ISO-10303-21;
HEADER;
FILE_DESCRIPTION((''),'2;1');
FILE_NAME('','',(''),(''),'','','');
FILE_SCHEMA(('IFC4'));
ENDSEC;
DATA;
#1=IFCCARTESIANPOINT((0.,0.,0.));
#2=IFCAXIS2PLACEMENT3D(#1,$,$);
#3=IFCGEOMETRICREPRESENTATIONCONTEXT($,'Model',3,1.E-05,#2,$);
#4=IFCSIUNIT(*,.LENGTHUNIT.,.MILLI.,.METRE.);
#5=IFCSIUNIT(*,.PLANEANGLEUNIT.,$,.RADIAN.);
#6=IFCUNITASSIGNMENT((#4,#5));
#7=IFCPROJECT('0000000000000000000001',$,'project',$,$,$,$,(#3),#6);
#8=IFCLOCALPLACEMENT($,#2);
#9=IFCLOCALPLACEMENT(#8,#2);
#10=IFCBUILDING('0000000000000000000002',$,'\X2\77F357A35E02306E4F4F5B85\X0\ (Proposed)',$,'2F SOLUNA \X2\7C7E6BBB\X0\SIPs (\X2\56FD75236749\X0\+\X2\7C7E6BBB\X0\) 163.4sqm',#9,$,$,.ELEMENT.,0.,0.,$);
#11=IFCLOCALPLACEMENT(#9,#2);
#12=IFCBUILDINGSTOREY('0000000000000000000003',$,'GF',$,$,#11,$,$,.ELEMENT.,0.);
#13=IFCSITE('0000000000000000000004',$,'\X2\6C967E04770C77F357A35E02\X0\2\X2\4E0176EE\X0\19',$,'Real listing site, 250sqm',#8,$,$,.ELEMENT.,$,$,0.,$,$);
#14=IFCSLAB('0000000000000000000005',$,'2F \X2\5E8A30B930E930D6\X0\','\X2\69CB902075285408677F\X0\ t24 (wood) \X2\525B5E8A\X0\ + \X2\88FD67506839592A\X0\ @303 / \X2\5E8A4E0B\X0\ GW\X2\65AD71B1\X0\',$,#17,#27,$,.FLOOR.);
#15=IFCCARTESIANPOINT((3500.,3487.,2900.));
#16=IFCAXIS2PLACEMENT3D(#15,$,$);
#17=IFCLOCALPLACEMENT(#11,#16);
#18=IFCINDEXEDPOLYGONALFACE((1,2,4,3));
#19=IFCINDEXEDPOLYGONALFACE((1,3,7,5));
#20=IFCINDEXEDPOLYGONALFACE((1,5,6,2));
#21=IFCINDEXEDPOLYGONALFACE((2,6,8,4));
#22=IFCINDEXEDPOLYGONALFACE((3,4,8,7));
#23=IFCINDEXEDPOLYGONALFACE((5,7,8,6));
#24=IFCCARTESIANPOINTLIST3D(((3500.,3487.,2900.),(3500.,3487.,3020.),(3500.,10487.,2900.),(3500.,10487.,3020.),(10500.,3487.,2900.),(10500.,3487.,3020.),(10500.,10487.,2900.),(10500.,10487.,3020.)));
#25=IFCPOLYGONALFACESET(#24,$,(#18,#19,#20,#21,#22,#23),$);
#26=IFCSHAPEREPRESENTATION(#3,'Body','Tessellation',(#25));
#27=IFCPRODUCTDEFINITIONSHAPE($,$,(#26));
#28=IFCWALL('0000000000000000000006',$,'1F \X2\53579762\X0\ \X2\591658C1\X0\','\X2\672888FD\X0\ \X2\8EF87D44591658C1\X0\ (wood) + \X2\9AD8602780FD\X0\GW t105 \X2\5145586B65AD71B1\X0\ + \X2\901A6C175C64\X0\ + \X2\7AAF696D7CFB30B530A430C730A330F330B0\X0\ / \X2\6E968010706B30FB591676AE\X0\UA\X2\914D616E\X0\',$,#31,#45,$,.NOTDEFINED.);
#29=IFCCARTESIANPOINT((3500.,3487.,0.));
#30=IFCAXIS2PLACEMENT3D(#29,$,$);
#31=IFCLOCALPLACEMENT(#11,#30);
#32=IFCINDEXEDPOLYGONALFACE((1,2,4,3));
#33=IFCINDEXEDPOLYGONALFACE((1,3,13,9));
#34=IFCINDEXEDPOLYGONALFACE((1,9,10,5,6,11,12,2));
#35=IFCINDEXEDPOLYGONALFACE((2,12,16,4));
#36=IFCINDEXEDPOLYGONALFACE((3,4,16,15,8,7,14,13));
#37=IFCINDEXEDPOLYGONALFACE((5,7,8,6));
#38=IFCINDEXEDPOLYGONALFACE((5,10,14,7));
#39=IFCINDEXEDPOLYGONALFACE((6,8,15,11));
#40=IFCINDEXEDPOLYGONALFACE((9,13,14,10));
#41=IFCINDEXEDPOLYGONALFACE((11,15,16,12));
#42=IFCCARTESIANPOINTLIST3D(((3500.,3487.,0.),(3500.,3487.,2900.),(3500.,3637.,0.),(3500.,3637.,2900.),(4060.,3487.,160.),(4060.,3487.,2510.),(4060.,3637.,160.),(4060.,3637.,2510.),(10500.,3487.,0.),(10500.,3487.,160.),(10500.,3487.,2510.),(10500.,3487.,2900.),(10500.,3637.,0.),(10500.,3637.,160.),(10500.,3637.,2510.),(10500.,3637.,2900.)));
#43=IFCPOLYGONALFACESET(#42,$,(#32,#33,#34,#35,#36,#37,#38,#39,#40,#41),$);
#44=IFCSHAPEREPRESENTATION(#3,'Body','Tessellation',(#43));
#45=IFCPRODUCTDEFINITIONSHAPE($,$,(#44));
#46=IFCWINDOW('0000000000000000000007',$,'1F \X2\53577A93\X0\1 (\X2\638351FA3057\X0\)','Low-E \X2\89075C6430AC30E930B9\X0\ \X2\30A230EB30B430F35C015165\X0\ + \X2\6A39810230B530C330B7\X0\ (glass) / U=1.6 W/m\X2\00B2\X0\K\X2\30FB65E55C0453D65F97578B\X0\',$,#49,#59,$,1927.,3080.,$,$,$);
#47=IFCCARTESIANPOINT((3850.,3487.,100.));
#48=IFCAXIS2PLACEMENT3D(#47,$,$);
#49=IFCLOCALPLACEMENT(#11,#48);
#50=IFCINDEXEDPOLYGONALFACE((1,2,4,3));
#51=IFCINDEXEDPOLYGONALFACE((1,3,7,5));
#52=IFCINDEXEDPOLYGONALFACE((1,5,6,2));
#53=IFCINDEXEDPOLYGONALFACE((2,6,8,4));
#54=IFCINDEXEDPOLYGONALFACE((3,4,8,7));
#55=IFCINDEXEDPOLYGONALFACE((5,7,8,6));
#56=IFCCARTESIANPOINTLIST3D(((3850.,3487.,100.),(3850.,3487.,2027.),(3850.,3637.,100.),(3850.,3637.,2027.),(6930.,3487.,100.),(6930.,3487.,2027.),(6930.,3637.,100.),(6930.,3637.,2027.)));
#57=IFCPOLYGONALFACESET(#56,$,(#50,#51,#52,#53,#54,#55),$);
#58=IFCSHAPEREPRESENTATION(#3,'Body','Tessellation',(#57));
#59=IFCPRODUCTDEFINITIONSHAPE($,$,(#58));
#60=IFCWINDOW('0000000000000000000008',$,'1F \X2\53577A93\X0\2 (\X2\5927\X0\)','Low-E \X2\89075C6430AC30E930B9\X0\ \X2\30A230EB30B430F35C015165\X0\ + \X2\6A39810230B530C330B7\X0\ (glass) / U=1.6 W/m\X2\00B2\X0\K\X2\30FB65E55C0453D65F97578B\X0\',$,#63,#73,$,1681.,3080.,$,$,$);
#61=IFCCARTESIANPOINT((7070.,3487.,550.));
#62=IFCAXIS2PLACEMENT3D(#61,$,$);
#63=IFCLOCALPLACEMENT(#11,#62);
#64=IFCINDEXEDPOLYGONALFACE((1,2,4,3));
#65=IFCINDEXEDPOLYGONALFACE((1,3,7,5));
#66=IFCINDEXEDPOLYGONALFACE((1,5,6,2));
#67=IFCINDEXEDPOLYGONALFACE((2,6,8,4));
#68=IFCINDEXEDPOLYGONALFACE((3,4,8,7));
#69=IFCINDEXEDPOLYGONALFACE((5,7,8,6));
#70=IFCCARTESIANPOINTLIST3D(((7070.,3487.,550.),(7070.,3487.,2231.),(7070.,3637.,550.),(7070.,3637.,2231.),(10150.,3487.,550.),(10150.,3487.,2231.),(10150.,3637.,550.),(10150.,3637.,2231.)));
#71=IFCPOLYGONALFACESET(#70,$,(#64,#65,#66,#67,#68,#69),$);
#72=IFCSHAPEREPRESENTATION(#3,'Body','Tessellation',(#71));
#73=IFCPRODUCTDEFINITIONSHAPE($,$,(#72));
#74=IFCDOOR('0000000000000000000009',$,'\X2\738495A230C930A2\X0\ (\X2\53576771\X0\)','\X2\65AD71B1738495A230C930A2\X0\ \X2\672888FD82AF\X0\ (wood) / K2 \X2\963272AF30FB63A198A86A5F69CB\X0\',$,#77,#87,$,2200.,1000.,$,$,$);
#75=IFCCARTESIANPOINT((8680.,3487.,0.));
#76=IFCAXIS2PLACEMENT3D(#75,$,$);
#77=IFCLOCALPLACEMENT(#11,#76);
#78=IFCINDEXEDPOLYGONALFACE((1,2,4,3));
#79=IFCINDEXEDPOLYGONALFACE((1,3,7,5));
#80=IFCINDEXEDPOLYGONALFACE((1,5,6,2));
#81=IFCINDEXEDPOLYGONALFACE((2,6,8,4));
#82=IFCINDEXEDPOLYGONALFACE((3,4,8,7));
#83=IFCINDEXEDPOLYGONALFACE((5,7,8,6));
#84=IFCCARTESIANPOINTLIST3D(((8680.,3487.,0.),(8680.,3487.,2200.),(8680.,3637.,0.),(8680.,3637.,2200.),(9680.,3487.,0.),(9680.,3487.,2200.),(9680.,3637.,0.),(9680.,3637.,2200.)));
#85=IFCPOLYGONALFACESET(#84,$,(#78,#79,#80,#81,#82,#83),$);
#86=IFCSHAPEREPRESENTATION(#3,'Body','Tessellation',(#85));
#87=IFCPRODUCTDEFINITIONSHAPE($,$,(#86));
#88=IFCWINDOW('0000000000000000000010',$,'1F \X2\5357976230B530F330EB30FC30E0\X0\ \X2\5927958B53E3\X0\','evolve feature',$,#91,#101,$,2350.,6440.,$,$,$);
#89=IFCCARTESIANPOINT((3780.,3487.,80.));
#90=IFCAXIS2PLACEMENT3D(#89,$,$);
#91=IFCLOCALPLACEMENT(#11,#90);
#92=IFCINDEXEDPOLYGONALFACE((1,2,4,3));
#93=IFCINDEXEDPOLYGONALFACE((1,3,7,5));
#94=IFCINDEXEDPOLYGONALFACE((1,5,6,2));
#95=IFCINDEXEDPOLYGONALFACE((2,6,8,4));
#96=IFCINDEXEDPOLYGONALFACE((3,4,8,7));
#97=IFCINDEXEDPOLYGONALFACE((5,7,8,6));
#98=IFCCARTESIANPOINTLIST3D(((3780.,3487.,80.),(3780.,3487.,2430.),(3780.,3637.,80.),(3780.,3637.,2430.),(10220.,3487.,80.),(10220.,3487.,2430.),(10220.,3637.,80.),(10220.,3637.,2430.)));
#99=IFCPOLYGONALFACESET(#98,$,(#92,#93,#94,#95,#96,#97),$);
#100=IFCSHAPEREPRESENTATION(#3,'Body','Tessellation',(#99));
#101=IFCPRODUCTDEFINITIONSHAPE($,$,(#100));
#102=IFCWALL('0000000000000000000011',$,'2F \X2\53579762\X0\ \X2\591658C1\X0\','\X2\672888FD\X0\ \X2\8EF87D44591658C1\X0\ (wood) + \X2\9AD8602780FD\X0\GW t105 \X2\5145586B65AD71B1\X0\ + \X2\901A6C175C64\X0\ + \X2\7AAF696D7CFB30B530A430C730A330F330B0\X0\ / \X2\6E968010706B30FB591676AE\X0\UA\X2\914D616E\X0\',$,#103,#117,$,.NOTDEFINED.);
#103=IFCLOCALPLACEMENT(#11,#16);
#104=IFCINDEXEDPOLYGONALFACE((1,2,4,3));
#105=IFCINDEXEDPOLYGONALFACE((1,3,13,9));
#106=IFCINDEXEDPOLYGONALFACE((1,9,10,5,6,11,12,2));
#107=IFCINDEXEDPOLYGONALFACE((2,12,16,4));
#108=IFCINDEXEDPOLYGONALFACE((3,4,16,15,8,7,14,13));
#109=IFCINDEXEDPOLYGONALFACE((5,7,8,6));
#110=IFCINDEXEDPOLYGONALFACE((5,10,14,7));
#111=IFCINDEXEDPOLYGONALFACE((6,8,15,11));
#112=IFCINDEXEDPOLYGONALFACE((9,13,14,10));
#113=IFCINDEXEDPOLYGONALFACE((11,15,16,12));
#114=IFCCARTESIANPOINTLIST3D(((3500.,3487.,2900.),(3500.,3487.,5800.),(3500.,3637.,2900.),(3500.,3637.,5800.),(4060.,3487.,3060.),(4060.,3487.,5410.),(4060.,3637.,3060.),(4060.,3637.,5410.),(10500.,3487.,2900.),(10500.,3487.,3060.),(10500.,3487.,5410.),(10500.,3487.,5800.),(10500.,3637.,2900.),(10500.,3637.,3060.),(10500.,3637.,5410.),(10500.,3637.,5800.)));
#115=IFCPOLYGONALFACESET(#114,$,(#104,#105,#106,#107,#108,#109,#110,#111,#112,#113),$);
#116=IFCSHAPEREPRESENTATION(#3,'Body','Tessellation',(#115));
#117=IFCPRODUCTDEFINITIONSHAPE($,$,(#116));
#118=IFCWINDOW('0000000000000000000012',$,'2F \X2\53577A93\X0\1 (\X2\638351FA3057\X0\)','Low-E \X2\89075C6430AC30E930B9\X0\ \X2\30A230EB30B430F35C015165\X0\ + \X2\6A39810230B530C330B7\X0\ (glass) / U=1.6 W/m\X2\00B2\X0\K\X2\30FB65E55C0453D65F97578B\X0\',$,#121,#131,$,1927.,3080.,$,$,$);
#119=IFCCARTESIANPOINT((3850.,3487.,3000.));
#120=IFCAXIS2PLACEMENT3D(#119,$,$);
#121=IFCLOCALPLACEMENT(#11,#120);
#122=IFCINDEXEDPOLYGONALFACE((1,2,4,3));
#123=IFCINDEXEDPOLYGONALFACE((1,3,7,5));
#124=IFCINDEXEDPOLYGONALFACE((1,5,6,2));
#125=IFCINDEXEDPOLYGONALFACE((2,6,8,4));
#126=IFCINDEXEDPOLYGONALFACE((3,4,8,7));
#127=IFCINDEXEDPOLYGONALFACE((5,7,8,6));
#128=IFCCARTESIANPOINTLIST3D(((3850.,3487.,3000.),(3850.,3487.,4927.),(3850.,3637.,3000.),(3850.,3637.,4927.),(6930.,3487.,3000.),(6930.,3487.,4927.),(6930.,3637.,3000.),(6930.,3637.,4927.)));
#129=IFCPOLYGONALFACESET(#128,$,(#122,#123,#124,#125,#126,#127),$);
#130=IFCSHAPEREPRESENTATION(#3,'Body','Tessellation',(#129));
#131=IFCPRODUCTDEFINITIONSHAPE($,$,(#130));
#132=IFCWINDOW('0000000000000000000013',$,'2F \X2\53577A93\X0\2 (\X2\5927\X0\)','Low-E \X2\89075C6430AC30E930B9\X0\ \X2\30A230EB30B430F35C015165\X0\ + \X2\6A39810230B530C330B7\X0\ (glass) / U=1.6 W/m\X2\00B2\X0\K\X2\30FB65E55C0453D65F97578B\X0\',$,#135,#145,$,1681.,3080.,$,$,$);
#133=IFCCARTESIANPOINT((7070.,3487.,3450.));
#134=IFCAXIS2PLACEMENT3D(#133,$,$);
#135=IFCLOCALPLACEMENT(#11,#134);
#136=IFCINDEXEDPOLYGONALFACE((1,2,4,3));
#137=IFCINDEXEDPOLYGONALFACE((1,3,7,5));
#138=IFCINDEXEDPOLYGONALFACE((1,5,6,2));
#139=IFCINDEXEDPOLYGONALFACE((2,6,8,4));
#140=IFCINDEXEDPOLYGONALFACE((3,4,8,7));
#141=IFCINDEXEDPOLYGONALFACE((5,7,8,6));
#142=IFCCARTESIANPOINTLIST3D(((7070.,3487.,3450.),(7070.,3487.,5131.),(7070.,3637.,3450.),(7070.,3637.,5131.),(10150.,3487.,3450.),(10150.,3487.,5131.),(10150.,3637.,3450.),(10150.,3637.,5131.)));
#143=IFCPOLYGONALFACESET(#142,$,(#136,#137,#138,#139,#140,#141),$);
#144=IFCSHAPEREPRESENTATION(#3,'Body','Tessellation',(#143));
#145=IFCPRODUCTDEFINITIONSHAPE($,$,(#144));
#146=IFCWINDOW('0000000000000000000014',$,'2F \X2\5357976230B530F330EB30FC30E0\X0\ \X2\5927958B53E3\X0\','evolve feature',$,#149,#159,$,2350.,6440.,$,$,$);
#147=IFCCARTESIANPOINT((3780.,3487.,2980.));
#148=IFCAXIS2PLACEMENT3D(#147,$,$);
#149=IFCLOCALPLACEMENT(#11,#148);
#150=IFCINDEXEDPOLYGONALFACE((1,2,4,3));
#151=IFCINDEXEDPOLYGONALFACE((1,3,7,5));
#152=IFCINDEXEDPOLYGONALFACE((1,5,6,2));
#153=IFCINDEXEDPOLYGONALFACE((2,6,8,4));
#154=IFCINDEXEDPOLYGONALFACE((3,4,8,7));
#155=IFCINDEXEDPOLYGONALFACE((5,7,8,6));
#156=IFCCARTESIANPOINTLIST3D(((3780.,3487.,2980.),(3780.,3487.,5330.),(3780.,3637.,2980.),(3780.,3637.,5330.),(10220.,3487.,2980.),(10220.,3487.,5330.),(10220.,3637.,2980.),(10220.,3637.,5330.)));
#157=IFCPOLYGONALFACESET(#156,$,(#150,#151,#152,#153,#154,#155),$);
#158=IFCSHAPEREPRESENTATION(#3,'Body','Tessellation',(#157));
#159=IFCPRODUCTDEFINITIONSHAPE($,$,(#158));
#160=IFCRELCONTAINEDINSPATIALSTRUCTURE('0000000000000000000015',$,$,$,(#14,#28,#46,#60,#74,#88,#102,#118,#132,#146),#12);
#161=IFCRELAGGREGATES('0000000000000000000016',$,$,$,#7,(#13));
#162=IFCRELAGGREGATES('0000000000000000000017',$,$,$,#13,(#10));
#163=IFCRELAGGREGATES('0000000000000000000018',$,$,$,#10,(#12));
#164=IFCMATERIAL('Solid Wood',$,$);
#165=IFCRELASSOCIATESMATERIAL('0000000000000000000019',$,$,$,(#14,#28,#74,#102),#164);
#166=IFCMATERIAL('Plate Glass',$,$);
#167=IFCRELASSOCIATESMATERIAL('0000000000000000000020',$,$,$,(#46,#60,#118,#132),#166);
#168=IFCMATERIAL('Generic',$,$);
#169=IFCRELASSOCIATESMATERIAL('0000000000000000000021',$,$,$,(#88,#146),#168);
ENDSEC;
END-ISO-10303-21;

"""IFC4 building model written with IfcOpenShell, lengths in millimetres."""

from ifc_helpers import new_model, si_unit, frame, frame_2d, origin, place, context, project, spatial, rectangle, extrude, material, element, fill, save


model = new_model("IFC4")

# Units and contexts
model_context = context("Model", 3, precision=1e-05, world=origin())
ifc_project = project(units=[si_unit("LENGTHUNIT", "METRE", prefix="MILLI"), si_unit("PLANEANGLEUNIT", "RADIAN")], contexts=[model_context])

# Site, building, storey
site_placement = place(None, origin())
site = spatial("IfcSite", under=ifc_project, at=site_placement, Name="沖縄県石垣市2丁目19", ObjectType="Real listing site, 250sqm", CompositionType="ELEMENT", RefElevation=0.0)
building_placement = place(site_placement, origin())
building = spatial("IfcBuilding", under=site, at=building_placement, Name="石垣市の住宅 (Proposed)", ObjectType="2F SOLUNA 籾殻SIPs (国産杉+籾殻) 163.4sqm", CompositionType="ELEMENT", ElevationOfRefHeight=0.0, ElevationOfTerrain=0.0)
storey_placement = place(building_placement, origin())
storey = spatial("IfcBuildingStorey", under=building, at=storey_placement, Name="GF", CompositionType="ELEMENT", Elevation=0.0)

# Slab
ifc_material_1 = material(Name="Solid Wood")
slab_1_placement = place(storey_placement, frame((3500.0, 3487.0, 2900.0)))
element("IfcSlab", 1, at=slab_1_placement, inside=storey, material=ifc_material_1, Name="2F 床スラブ", Description="構造用合板 t24 (wood) 剛床 + 製材根太 @303 / 床下 GW断熱", PredefinedType="FLOOR", context=model_context, shape_type="SweptSolid", body=[
    extrude(rectangle(XDim=7000.0, YDim=7000.0, at=frame_2d((3500.0, 3500.0))), frame((3500.0, 3487.0, 2900.0)), (0.0, 0.0, 1.0), 120.0),
])
ifc_material_2 = material(Name="Generic")

# Wall, openings, windows, door
wall_1_placement = place(storey_placement, frame((3500.0, 3487.0, 0.0)))
wall_1 = element("IfcWall", 2, at=wall_1_placement, inside=storey, material=ifc_material_1, Name="1F 南面 外壁", Description="木製 軸組外壁 (wood) + 高性能GW t105 充填断熱 + 通気層 + 窯業系サイディング / 準耐火・外皮UA配慮", PredefinedType="NOTDEFINED", context=model_context, shape_type="SweptSolid", body=[
    extrude(rectangle(XDim=7000.0, YDim=150.0, at=frame_2d((3500.0, 75.0))), frame((3500.0, 3487.0, 0.0)), (0.0, 0.0, 1.0), 2900.0),
])
opening_1_placement = place(storey_placement, frame((3850.0, 3487.0, 100.0)))
opening_1 = element("IfcOpeningElement", 3, at=opening_1_placement, cuts=wall_1, PredefinedType="NOTDEFINED", context=model_context, shape_type="SweptSolid", body=[
    extrude(rectangle(XDim=3080.0, YDim=150.0, at=frame_2d((1540.0, 75.0))), frame((3850.0, 3487.0, 100.0)), (0.0, 0.0, 1.0), 1927.0),
])
opening_2_placement = place(storey_placement, frame((7070.0, 3487.0, 550.0)))
opening_2 = element("IfcOpeningElement", 4, at=opening_2_placement, cuts=wall_1, PredefinedType="NOTDEFINED", context=model_context, shape_type="SweptSolid", body=[
    extrude(rectangle(XDim=3080.0, YDim=150.0, at=frame_2d((1540.0, 75.0))), frame((7070.0, 3487.0, 550.0)), (0.0, 0.0, 1.0), 1681.0),
])
opening_3_placement = place(storey_placement, frame((8680.0, 3487.0, 0.0)))
opening_3 = element("IfcOpeningElement", 5, at=opening_3_placement, cuts=wall_1, PredefinedType="NOTDEFINED", context=model_context, shape_type="SweptSolid", body=[
    extrude(rectangle(XDim=1000.0, YDim=150.0, at=frame_2d((500.0, 75.0))), frame((8680.0, 3487.0, 0.0)), (0.0, 0.0, 1.0), 2200.0),
])
opening_4_placement = place(storey_placement, frame((3780.0, 3487.0, 80.0)))
opening_4 = element("IfcOpeningElement", 6, at=opening_4_placement, cuts=wall_1, PredefinedType="NOTDEFINED", context=model_context, shape_type="SweptSolid", body=[
    extrude(rectangle(XDim=6440.0, YDim=150.0, at=frame_2d((3220.0, 75.0))), frame((3780.0, 3487.0, 80.0)), (0.0, 0.0, 1.0), 2350.0),
])
ifc_material_3 = material(Name="Plate Glass")
window_1_placement = place(storey_placement, frame((3850.0, 3487.0, 100.0)))
window_1 = element("IfcWindow", 7, at=window_1_placement, inside=storey, material=ifc_material_3, Name="1F 南窓1 (掃出し)", Description="Low-E 複層ガラス アルゴン封入 + 樹脂サッシ (glass) / U=1.6 W/m²K・日射取得型", OverallHeight=1927.0, OverallWidth=3080.0, context=model_context, shape_type="SweptSolid", body=[
    extrude(rectangle(XDim=3080.0, YDim=150.0, at=frame_2d((1540.0, 75.0))), frame((3850.0, 3487.0, 100.0)), (0.0, 0.0, 1.0), 1927.0),
])
fill(opening_1, window_1)
window_2_placement = place(storey_placement, frame((7070.0, 3487.0, 550.0)))
window_2 = element("IfcWindow", 8, at=window_2_placement, inside=storey, material=ifc_material_3, Name="1F 南窓2 (大)", Description="Low-E 複層ガラス アルゴン封入 + 樹脂サッシ (glass) / U=1.6 W/m²K・日射取得型", OverallHeight=1681.0, OverallWidth=3080.0, context=model_context, shape_type="SweptSolid", body=[
    extrude(rectangle(XDim=3080.0, YDim=150.0, at=frame_2d((1540.0, 75.0))), frame((7070.0, 3487.0, 550.0)), (0.0, 0.0, 1.0), 1681.0),
])
fill(opening_2, window_2)
door_placement = place(storey_placement, frame((8680.0, 3487.0, 0.0)))
door = element("IfcDoor", 9, at=door_placement, inside=storey, material=ifc_material_1, Name="玄関ドア (南東)", Description="断熱玄関ドア 木製芯 (wood) / K2 防犯・採風機構", OverallHeight=2200.0, OverallWidth=1000.0, context=model_context, shape_type="SweptSolid", body=[
    extrude(rectangle(XDim=1000.0, YDim=150.0, at=frame_2d((500.0, 75.0))), frame((8680.0, 3487.0, 0.0)), (0.0, 0.0, 1.0), 2200.0),
])
fill(opening_3, door)
window_3_placement = place(storey_placement, frame((3780.0, 3487.0, 80.0)))
window_3 = element("IfcWindow", 10, at=window_3_placement, inside=storey, material=ifc_material_2, Name="1F 南面サンルーム 大開口", Description="evolve feature", OverallHeight=2350.0, OverallWidth=6440.0, context=model_context, shape_type="SweptSolid", body=[
    extrude(rectangle(XDim=6440.0, YDim=150.0, at=frame_2d((3220.0, 75.0))), frame((3780.0, 3487.0, 80.0)), (0.0, 0.0, 1.0), 2350.0),
])
fill(opening_4, window_3)

# Wall, openings, windows
wall_2_placement = place(storey_placement, frame((3500.0, 3487.0, 2900.0)))
wall_2 = element("IfcWall", 11, at=wall_2_placement, inside=storey, material=ifc_material_1, Name="2F 南面 外壁", Description="木製 軸組外壁 (wood) + 高性能GW t105 充填断熱 + 通気層 + 窯業系サイディング / 準耐火・外皮UA配慮", PredefinedType="NOTDEFINED", context=model_context, shape_type="SweptSolid", body=[
    extrude(rectangle(XDim=7000.0, YDim=150.0, at=frame_2d((3500.0, 75.0))), frame((3500.0, 3487.0, 2900.0)), (0.0, 0.0, 1.0), 2900.0),
])
opening_5_placement = place(storey_placement, frame((3850.0, 3487.0, 3000.0)))
opening_5 = element("IfcOpeningElement", 12, at=opening_5_placement, cuts=wall_2, PredefinedType="NOTDEFINED", context=model_context, shape_type="SweptSolid", body=[
    extrude(rectangle(XDim=3080.0, YDim=150.0, at=frame_2d((1540.0, 75.0))), frame((3850.0, 3487.0, 3000.0)), (0.0, 0.0, 1.0), 1927.0),
])
opening_6_placement = place(storey_placement, frame((7070.0, 3487.0, 3450.0)))
opening_6 = element("IfcOpeningElement", 13, at=opening_6_placement, cuts=wall_2, PredefinedType="NOTDEFINED", context=model_context, shape_type="SweptSolid", body=[
    extrude(rectangle(XDim=3080.0, YDim=150.0, at=frame_2d((1540.0, 75.0))), frame((7070.0, 3487.0, 3450.0)), (0.0, 0.0, 1.0), 1681.0),
])
opening_7_placement = place(storey_placement, frame((3780.0, 3487.0, 2980.0)))
opening_7 = element("IfcOpeningElement", 14, at=opening_7_placement, cuts=wall_2, PredefinedType="NOTDEFINED", context=model_context, shape_type="SweptSolid", body=[
    extrude(rectangle(XDim=6440.0, YDim=150.0, at=frame_2d((3220.0, 75.0))), frame((3780.0, 3487.0, 2980.0)), (0.0, 0.0, 1.0), 2350.0),
])
window_4_placement = place(storey_placement, frame((3850.0, 3487.0, 3000.0)))
window_4 = element("IfcWindow", 15, at=window_4_placement, inside=storey, material=ifc_material_3, Name="2F 南窓1 (掃出し)", Description="Low-E 複層ガラス アルゴン封入 + 樹脂サッシ (glass) / U=1.6 W/m²K・日射取得型", OverallHeight=1927.0, OverallWidth=3080.0, context=model_context, shape_type="SweptSolid", body=[
    extrude(rectangle(XDim=3080.0, YDim=150.0, at=frame_2d((1540.0, 75.0))), frame((3850.0, 3487.0, 3000.0)), (0.0, 0.0, 1.0), 1927.0),
])
fill(opening_5, window_4)
window_5_placement = place(storey_placement, frame((7070.0, 3487.0, 3450.0)))
window_5 = element("IfcWindow", 16, at=window_5_placement, inside=storey, material=ifc_material_3, Name="2F 南窓2 (大)", Description="Low-E 複層ガラス アルゴン封入 + 樹脂サッシ (glass) / U=1.6 W/m²K・日射取得型", OverallHeight=1681.0, OverallWidth=3080.0, context=model_context, shape_type="SweptSolid", body=[
    extrude(rectangle(XDim=3080.0, YDim=150.0, at=frame_2d((1540.0, 75.0))), frame((7070.0, 3487.0, 3450.0)), (0.0, 0.0, 1.0), 1681.0),
])
fill(opening_6, window_5)
window_6_placement = place(storey_placement, frame((3780.0, 3487.0, 2980.0)))
window_6 = element("IfcWindow", 17, at=window_6_placement, inside=storey, material=ifc_material_2, Name="2F 南面サンルーム 大開口", Description="evolve feature", OverallHeight=2350.0, OverallWidth=6440.0, context=model_context, shape_type="SweptSolid", body=[
    extrude(rectangle(XDim=6440.0, YDim=150.0, at=frame_2d((3220.0, 75.0))), frame((3780.0, 3487.0, 2980.0)), (0.0, 0.0, 1.0), 2350.0),
])
fill(opening_7, window_6)

save(model, "model.ifc")
